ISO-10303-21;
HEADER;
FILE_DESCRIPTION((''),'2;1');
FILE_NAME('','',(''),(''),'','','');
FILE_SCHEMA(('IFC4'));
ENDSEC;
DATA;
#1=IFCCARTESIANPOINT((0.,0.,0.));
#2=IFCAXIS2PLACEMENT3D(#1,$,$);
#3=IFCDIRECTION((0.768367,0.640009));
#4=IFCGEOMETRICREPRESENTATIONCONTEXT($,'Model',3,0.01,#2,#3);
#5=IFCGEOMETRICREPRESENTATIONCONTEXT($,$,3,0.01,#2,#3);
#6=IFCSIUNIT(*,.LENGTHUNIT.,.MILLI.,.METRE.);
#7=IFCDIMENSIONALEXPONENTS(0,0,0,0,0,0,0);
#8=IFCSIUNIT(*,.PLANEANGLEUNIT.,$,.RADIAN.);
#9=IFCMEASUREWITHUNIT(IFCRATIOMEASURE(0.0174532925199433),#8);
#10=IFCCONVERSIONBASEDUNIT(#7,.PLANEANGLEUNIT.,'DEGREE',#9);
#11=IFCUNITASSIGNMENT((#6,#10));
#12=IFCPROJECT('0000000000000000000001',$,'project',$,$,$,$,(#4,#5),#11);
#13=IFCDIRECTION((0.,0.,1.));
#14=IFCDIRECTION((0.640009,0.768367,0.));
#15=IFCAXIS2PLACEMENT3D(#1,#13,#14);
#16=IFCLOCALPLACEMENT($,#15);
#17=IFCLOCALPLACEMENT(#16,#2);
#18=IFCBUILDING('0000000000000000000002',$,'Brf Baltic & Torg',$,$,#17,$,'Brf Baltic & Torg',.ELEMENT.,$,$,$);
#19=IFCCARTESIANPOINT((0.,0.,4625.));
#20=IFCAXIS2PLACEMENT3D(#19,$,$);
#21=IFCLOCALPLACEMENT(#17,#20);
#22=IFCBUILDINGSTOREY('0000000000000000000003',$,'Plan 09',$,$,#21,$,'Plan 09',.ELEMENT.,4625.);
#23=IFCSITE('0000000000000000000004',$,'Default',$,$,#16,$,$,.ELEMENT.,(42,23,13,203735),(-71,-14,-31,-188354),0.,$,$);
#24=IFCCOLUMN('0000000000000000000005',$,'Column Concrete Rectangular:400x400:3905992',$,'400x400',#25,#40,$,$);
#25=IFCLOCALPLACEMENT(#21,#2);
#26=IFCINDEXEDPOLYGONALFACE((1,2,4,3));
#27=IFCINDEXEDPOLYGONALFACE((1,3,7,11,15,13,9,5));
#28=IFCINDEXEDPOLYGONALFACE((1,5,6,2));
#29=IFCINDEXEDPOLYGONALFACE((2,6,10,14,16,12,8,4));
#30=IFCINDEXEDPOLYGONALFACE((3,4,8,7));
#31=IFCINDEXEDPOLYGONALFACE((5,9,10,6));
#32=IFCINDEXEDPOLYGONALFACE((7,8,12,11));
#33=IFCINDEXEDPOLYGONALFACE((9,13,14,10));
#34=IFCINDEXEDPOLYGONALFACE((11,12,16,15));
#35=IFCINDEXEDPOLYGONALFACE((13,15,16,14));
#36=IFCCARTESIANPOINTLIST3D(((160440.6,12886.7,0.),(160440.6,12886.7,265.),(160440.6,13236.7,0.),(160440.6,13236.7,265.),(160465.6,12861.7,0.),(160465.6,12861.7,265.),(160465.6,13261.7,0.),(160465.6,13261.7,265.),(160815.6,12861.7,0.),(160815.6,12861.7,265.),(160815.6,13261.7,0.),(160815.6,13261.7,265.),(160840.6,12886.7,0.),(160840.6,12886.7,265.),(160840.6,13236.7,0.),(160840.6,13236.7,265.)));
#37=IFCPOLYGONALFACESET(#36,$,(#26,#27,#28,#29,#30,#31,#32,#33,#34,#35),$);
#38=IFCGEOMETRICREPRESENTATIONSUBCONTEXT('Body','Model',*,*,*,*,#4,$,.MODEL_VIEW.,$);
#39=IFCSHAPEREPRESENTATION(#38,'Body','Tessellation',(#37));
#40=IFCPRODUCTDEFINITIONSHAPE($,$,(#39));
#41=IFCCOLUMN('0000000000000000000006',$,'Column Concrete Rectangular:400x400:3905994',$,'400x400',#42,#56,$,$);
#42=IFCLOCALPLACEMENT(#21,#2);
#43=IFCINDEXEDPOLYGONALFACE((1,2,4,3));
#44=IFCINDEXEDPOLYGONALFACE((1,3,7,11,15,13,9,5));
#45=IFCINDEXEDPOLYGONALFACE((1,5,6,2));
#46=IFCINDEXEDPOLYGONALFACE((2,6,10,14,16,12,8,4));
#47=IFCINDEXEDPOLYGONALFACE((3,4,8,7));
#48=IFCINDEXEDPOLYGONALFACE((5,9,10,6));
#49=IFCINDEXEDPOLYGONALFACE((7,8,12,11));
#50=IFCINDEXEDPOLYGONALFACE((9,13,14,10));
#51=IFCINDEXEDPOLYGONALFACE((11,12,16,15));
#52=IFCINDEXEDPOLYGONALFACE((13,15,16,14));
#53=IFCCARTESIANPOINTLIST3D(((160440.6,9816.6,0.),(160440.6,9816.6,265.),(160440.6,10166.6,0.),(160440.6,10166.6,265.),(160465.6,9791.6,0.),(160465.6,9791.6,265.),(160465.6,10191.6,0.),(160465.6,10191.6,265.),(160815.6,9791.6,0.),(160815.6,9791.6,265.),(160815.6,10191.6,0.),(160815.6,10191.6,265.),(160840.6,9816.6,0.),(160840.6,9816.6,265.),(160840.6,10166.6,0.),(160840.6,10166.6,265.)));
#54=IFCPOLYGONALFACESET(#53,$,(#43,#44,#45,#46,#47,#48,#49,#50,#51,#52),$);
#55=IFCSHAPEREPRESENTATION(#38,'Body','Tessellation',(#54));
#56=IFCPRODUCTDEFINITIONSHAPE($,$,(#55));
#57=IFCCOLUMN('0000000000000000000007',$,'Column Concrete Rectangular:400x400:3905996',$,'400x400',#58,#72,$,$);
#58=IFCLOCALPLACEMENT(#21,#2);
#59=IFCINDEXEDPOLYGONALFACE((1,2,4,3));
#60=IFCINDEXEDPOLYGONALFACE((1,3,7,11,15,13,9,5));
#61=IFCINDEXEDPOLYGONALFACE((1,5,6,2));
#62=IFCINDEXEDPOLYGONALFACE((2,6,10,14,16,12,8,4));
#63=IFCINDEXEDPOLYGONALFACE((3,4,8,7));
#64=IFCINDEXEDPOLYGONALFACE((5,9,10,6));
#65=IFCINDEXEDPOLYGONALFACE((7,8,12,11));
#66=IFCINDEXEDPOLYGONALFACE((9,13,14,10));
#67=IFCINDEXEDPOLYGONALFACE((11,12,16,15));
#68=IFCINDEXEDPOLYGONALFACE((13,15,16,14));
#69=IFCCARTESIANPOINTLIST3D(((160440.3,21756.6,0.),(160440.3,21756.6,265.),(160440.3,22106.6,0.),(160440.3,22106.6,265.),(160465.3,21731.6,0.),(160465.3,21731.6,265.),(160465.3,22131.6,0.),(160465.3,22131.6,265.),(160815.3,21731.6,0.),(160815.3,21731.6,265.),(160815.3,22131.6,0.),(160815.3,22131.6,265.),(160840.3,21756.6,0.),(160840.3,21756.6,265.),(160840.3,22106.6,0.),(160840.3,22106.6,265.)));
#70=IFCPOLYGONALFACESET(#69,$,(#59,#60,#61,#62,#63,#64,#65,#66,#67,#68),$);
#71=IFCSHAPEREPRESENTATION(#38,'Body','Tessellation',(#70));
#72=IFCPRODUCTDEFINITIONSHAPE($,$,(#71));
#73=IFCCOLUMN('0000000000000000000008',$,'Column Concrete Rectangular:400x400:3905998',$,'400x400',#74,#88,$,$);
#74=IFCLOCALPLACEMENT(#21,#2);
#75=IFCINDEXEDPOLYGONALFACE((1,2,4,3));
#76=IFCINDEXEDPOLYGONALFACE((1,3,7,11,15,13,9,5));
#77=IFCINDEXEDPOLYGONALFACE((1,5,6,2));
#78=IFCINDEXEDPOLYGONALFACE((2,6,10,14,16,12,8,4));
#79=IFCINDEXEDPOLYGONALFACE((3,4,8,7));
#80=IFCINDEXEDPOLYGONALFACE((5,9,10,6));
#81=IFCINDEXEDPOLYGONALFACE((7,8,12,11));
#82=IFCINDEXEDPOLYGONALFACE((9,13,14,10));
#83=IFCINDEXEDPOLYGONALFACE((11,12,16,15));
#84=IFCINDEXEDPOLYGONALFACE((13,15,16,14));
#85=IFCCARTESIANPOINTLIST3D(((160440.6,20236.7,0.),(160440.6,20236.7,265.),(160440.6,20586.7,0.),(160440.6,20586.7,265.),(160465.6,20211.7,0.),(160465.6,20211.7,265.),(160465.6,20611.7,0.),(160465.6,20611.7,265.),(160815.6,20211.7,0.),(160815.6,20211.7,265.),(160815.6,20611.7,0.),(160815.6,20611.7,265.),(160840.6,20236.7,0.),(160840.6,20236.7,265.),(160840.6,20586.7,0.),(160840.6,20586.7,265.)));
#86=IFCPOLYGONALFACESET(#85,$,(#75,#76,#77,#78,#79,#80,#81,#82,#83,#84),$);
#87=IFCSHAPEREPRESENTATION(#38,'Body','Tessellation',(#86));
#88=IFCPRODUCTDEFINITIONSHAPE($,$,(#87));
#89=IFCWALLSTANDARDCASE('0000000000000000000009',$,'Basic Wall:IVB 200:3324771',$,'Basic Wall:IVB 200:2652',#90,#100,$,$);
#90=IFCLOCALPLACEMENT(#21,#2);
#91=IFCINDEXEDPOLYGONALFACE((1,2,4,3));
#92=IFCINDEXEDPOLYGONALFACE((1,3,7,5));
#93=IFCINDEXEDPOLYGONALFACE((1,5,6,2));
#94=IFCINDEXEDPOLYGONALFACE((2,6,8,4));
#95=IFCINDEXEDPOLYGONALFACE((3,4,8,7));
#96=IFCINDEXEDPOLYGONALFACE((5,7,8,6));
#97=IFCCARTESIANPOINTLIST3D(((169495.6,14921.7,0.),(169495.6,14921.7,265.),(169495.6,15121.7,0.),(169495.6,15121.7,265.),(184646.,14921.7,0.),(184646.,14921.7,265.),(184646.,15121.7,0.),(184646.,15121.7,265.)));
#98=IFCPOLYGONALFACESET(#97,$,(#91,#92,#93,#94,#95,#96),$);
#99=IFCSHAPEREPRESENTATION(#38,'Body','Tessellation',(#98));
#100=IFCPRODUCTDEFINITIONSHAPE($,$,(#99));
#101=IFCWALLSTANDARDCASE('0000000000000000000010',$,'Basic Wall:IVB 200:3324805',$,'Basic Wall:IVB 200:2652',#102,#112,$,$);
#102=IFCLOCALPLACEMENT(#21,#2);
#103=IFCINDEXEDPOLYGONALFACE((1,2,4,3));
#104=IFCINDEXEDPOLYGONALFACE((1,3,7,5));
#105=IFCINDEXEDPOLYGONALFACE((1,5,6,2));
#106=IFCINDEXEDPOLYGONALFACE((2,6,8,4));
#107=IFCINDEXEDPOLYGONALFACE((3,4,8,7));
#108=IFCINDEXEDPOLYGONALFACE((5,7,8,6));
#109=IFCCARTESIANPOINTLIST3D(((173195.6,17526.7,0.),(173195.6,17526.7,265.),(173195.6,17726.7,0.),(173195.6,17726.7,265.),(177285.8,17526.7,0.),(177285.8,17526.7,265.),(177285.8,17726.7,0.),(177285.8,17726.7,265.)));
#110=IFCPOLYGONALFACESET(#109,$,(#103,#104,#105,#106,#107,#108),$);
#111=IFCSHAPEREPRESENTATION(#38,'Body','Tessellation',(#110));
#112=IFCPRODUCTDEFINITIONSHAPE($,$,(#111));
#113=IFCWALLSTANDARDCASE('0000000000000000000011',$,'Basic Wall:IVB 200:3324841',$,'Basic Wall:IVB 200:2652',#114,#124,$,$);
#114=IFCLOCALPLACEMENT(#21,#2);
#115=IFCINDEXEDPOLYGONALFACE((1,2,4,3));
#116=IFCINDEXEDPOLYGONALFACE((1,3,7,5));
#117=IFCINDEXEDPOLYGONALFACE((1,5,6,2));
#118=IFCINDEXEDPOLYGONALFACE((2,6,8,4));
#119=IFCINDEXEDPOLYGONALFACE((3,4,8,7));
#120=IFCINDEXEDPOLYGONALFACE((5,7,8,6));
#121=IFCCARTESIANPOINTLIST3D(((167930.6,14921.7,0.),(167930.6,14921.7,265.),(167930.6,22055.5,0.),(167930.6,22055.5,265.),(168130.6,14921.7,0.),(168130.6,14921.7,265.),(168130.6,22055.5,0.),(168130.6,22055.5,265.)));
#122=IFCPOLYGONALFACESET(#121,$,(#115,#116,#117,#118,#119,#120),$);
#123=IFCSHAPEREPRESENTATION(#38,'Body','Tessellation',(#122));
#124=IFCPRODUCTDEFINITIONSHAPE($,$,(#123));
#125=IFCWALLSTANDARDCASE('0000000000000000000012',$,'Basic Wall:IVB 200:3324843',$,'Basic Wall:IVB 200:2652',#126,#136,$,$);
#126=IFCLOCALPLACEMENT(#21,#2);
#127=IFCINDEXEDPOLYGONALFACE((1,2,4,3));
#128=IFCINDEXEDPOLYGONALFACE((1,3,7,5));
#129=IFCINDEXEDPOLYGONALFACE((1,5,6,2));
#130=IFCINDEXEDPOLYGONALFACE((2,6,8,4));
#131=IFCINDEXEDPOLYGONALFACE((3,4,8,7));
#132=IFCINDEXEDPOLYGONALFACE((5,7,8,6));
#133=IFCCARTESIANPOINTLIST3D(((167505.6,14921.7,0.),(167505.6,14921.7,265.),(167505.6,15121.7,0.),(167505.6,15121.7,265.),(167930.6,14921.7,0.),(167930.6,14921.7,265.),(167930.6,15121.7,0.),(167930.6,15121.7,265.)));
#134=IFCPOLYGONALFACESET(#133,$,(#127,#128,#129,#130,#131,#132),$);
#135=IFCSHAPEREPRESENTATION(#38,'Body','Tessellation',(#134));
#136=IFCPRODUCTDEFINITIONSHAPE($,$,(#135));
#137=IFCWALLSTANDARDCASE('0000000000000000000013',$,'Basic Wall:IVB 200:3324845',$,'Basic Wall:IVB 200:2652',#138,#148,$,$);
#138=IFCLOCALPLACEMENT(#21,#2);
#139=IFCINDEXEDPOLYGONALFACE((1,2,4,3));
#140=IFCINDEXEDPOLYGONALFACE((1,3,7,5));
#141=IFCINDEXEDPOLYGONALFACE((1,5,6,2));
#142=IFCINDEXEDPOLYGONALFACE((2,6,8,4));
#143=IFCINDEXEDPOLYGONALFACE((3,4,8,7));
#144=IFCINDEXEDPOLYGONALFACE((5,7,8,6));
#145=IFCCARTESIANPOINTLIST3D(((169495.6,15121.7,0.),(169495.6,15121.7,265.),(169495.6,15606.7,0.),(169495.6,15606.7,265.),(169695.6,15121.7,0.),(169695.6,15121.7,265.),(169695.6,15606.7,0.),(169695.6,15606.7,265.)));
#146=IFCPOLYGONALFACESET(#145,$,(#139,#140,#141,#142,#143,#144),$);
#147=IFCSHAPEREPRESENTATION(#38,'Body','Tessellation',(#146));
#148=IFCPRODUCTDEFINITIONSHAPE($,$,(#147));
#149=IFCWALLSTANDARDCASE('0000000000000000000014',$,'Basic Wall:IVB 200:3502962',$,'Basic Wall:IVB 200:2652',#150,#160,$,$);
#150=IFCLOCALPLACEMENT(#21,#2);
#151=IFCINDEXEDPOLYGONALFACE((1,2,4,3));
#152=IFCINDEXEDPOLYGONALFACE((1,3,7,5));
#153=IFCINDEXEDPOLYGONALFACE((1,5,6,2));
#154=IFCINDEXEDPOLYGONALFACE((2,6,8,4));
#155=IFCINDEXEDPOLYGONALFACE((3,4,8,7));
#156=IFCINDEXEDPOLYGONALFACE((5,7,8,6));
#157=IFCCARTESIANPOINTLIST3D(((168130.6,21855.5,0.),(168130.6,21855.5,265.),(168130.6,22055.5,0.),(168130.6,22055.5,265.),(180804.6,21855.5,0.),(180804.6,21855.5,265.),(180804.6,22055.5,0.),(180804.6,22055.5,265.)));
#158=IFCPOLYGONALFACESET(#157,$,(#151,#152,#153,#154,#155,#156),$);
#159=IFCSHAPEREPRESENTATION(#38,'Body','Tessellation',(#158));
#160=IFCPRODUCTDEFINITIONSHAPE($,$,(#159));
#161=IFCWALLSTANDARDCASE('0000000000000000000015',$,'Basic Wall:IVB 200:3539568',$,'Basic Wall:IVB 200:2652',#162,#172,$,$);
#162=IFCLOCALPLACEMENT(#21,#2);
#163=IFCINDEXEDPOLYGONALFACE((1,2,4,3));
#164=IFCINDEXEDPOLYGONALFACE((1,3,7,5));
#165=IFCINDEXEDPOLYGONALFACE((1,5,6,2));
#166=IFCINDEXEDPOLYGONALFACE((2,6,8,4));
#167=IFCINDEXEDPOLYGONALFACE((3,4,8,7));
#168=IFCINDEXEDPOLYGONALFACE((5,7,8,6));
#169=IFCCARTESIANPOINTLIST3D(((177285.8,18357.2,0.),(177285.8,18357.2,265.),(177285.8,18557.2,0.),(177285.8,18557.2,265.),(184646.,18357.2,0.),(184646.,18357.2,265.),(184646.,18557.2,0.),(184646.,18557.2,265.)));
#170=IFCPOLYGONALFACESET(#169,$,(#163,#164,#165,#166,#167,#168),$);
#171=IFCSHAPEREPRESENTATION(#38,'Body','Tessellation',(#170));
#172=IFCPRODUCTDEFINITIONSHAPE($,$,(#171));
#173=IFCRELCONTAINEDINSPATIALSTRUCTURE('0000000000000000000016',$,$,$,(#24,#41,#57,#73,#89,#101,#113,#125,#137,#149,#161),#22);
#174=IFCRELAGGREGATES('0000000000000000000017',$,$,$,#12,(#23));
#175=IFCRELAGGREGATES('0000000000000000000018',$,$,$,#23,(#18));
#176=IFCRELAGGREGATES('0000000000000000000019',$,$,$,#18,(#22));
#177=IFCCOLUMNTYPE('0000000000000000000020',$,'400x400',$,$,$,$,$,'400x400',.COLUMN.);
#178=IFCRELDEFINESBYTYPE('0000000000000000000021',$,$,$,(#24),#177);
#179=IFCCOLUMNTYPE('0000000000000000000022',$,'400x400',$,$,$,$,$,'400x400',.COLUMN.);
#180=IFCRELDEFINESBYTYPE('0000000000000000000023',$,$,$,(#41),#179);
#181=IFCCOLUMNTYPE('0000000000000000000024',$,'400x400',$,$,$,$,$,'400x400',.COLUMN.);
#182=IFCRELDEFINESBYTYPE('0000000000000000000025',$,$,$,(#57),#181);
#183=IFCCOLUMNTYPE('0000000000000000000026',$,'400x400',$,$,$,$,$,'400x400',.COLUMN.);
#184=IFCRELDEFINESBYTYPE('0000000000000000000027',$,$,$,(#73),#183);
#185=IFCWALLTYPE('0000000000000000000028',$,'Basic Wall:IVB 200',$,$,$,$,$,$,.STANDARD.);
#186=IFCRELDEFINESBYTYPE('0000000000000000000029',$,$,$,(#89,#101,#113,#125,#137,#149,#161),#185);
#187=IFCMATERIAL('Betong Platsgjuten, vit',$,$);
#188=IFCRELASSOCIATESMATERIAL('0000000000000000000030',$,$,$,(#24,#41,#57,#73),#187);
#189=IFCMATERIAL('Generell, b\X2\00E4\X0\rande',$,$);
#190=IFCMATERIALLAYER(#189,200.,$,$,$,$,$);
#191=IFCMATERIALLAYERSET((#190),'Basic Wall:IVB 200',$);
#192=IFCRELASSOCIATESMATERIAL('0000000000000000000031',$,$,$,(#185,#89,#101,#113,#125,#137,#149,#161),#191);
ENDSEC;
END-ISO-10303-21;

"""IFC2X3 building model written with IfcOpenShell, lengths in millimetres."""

from ifc_helpers import new_model, entity, si_unit, converted_unit, direction, frame, frame_2d, origin, place, context, subcontext, project, spatial, polyline, rectangle, outline, extrude, clip, halfspace, source, transform, mapped, material, layer, layer_set, layer_usage, type_object, type_shapes, element, save


model = new_model("IFC2X3")

# Units and contexts
model_context = context("Model", 3, precision=0.01, world=origin(), true_north=direction((0.768367, 0.640009)))
context_of_model = context(None, 3, precision=0.01, world=origin(), true_north=direction((0.768367, 0.640009)))
body_context = subcontext(model_context, "Body", "Model", "MODEL_VIEW")
ifc_project = project(units=[si_unit("LENGTHUNIT", "METRE", prefix="MILLI"), converted_unit("PLANEANGLEUNIT", "DEGREE", entity("IfcRatioMeasure", 0.0174532925199433), si_unit("PLANEANGLEUNIT", "RADIAN"), dimensions=[0, 0, 0, 0, 0, 0, 0])], contexts=[model_context, context_of_model])

# Site, building, storey
site_placement = place(None, frame((0.0, 0.0, 0.0), z_axis=(0.0, 0.0, 1.0), x_axis=(0.640009, 0.768367, 0.0)))
site = spatial("IfcSite", under=ifc_project, at=site_placement, Name="Default", CompositionType="ELEMENT", RefLatitude=(42, 23, 13, 203735), RefLongitude=(-71, -14, -31, -188354), RefElevation=0.0)
building_placement = place(site_placement, origin())
building = spatial("IfcBuilding", under=site, at=building_placement, Name="Brf Baltic & Torg", LongName="Brf Baltic & Torg", CompositionType="ELEMENT")
storey_placement = place(building_placement, frame((0.0, 0.0, 4625.0)))
storey = spatial("IfcBuildingStorey", under=building, at=storey_placement, Name="Plan 09", LongName="Plan 09", CompositionType="ELEMENT", Elevation=4625.0)

# Columns
ifc_material_1 = material(Name="Betong Platsgjuten, vit")
column_type_1 = type_object("IfcColumnType", Name="400x400", ElementType="400x400", PredefinedType="COLUMN")
shared_shape_1 = source(origin(), body_context, "Body", "SweptSolid", [
    extrude(outline(polyline([(-175.0, -200.0), (175.0, -200.0), (200.0, -175.0), (200.0, 175.0), (175.0, 200.0), (-175.0, 200.0), (-200.0, 175.0), (-200.0, -175.0), (-175.0, -200.0)])), frame((0.0, 0.0, 4625.0), z_axis=(0.0, 0.0, 1.0), x_axis=(0.0, -1.0, 0.0)), (0.0, 0.0, 1.0), 265.0),
])
type_shapes(column_type_1, [shared_shape_1])
column_1_placement = place(storey_placement, frame((160640.6, 13061.7, -4625.0)))
element("IfcColumn", 1, at=column_1_placement, inside=storey, type_object=column_type_1, material=ifc_material_1, Name="Column Concrete Rectangular:400x400:3905992", ObjectType="400x400", context=body_context, shape_type="MappedRepresentation", body=[
    mapped(shared_shape_1, transform((0.0, 0.0, 0.0), scale=1.0)),
])
column_type_2 = type_object("IfcColumnType", Name="400x400", ElementType="400x400", PredefinedType="COLUMN")
shared_shape_2 = source(origin(), body_context, "Body", "SweptSolid", [
    extrude(outline(polyline([(-175.0, -200.0), (175.0, -200.0), (200.0, -175.0), (200.0, 175.0), (175.0, 200.0), (-175.0, 200.0), (-200.0, 175.0), (-200.0, -175.0), (-175.0, -200.0)])), frame((0.0, 0.0, 4625.0), z_axis=(0.0, 0.0, 1.0), x_axis=(0.0, -1.0, 0.0)), (0.0, 0.0, 1.0), 265.0),
])
type_shapes(column_type_2, [shared_shape_2])
column_2_placement = place(storey_placement, frame((160640.6, 9991.6, -4625.0)))
element("IfcColumn", 2, at=column_2_placement, inside=storey, type_object=column_type_2, material=ifc_material_1, Name="Column Concrete Rectangular:400x400:3905994", ObjectType="400x400", context=body_context, shape_type="MappedRepresentation", body=[
    mapped(shared_shape_2, transform((0.0, 0.0, 0.0), scale=1.0)),
])
column_type_3 = type_object("IfcColumnType", Name="400x400", ElementType="400x400", PredefinedType="COLUMN")
shared_shape_3 = source(origin(), body_context, "Body", "SweptSolid", [
    extrude(outline(polyline([(-175.0, -200.0), (175.0, -200.0), (200.0, -175.0), (200.0, 175.0), (175.0, 200.0), (-175.0, 200.0), (-200.0, 175.0), (-200.0, -175.0), (-175.0, -200.0)])), frame((0.0, 0.0, 4625.0), z_axis=(0.0, 0.0, 1.0), x_axis=(0.0, -1.0, 0.0)), (0.0, 0.0, 1.0), 265.0),
])
type_shapes(column_type_3, [shared_shape_3])
column_3_placement = place(storey_placement, frame((160640.3, 21931.6, -4625.0)))
element("IfcColumn", 3, at=column_3_placement, inside=storey, type_object=column_type_3, material=ifc_material_1, Name="Column Concrete Rectangular:400x400:3905996", ObjectType="400x400", context=body_context, shape_type="MappedRepresentation", body=[
    mapped(shared_shape_3, transform((0.0, 0.0, 0.0), scale=1.0)),
])
column_type_4 = type_object("IfcColumnType", Name="400x400", ElementType="400x400", PredefinedType="COLUMN")
shared_shape_4 = source(origin(), body_context, "Body", "SweptSolid", [
    extrude(outline(polyline([(-175.0, -200.0), (175.0, -200.0), (200.0, -175.0), (200.0, 175.0), (175.0, 200.0), (-175.0, 200.0), (-200.0, 175.0), (-200.0, -175.0), (-175.0, -200.0)])), frame((0.0, 0.0, 4625.0), z_axis=(0.0, 0.0, 1.0), x_axis=(0.0, -1.0, 0.0)), (0.0, 0.0, 1.0), 265.0),
])
type_shapes(column_type_4, [shared_shape_4])
column_4_placement = place(storey_placement, frame((160640.6, 20411.7, -4625.0)))
element("IfcColumn", 4, at=column_4_placement, inside=storey, type_object=column_type_4, material=ifc_material_1, Name="Column Concrete Rectangular:400x400:3905998", ObjectType="400x400", context=body_context, shape_type="MappedRepresentation", body=[
    mapped(shared_shape_4, transform((0.0, 0.0, 0.0), scale=1.0)),
])

# Wall
ifc_material_2 = material(Name="Generell, bärande")
ifc_layer = layer(ifc_material_2, 200.0)
ifc_layer_set = layer_set([ifc_layer], Name="Basic Wall:IVB 200")
ifc_layer_usage_1 = layer_usage(ifc_layer_set, "AXIS2", "NEGATIVE", 100.0)
wall_type = type_object("IfcWallType", Name="Basic Wall:IVB 200", PredefinedType="STANDARD", material=ifc_layer_set)
wall_1_placement = place(storey_placement, frame((169495.6, 15021.7, 0.0)))
element("IfcWallStandardCase", 5, at=wall_1_placement, inside=storey, type_object=wall_type, material=ifc_layer_usage_1, Name="Basic Wall:IVB 200:3324771", ObjectType="Basic Wall:IVB 200:2652", context=body_context, shape_type="Clipping", body=[
    clip(extrude(rectangle(XDim=15150.4, YDim=200.0, at=frame_2d((7575.2, 0.0), x_axis=(-1.0, 0.0))), origin(), (0.0, 0.0, 1.0), 265.0), halfspace(origin(), True)),
])

# Walls
ifc_layer_usage_2 = layer_usage(ifc_layer_set, "AXIS2", "NEGATIVE", 100.0)
wall_2_placement = place(storey_placement, frame((173195.6, 17626.7, 0.0)))
element("IfcWallStandardCase", 6, at=wall_2_placement, inside=storey, type_object=wall_type, material=ifc_layer_usage_2, Name="Basic Wall:IVB 200:3324805", ObjectType="Basic Wall:IVB 200:2652", context=body_context, shape_type="Clipping", body=[
    clip(extrude(rectangle(XDim=4090.2, YDim=200.0, at=frame_2d((2045.1, 0.0), x_axis=(-1.0, 0.0))), origin(), (0.0, 0.0, 1.0), 265.0), halfspace(origin(), True)),
])
ifc_layer_usage_3 = layer_usage(ifc_layer_set, "AXIS2", "NEGATIVE", 100.0)
wall_3_placement = place(storey_placement, frame((168030.6, 22055.5, 0.0), z_axis=(0.0, 0.0, 1.0), x_axis=(0.0, -1.0, 0.0)))
element("IfcWallStandardCase", 7, at=wall_3_placement, inside=storey, type_object=wall_type, material=ifc_layer_usage_3, Name="Basic Wall:IVB 200:3324841", ObjectType="Basic Wall:IVB 200:2652", context=body_context, shape_type="Clipping", body=[
    clip(extrude(rectangle(XDim=7133.7, YDim=200.0, at=frame_2d((3566.9, 0.0), x_axis=(-1.0, 0.0))), origin(), (0.0, 0.0, 1.0), 265.0), halfspace(origin(), True)),
])

# Walls
ifc_layer_usage_4 = layer_usage(ifc_layer_set, "AXIS2", "POSITIVE", -100.0)
wall_4_placement = place(storey_placement, frame((167930.6, 15021.7, 0.0), z_axis=(0.0, 0.0, 1.0), x_axis=(-1.0, 0.0, 0.0)))
element("IfcWallStandardCase", 8, at=wall_4_placement, inside=storey, type_object=wall_type, material=ifc_layer_usage_4, Name="Basic Wall:IVB 200:3324843", ObjectType="Basic Wall:IVB 200:2652", context=body_context, shape_type="Clipping", body=[
    clip(extrude(rectangle(XDim=425.0, YDim=200.0, at=frame_2d((212.5, 0.0), x_axis=(-1.0, 0.0))), origin(), (0.0, 0.0, 1.0), 265.0), halfspace(origin(), True)),
])
ifc_layer_usage_5 = layer_usage(ifc_layer_set, "AXIS2", "POSITIVE", -100.0)
wall_5_placement = place(storey_placement, frame((169595.6, 15606.7, 0.0), z_axis=(0.0, 0.0, 1.0), x_axis=(0.0, -1.0, 0.0)))
element("IfcWallStandardCase", 9, at=wall_5_placement, inside=storey, type_object=wall_type, material=ifc_layer_usage_5, Name="Basic Wall:IVB 200:3324845", ObjectType="Basic Wall:IVB 200:2652", context=body_context, shape_type="Clipping", body=[
    clip(extrude(rectangle(XDim=485.0, YDim=200.0, at=frame_2d((242.5, 0.0), x_axis=(-1.0, 0.0))), origin(), (0.0, 0.0, 1.0), 265.0), halfspace(origin(), True)),
])
ifc_layer_usage_6 = layer_usage(ifc_layer_set, "AXIS2", "NEGATIVE", 100.0)
wall_6_placement = place(storey_placement, frame((168130.6, 21955.5, 0.0)))
element("IfcWallStandardCase", 10, at=wall_6_placement, inside=storey, type_object=wall_type, material=ifc_layer_usage_6, Name="Basic Wall:IVB 200:3502962", ObjectType="Basic Wall:IVB 200:2652", context=body_context, shape_type="Clipping", body=[
    clip(extrude(rectangle(XDim=12674.0, YDim=200.0, at=frame_2d((6337.0, 0.0), x_axis=(-1.0, 0.0))), origin(), (0.0, 0.0, 1.0), 265.0), halfspace(origin(), True)),
])
ifc_layer_usage_7 = layer_usage(ifc_layer_set, "AXIS2", "NEGATIVE", 100.0)
wall_7_placement = place(storey_placement, frame((177285.8, 18457.2, 0.0)))
element("IfcWallStandardCase", 11, at=wall_7_placement, inside=storey, type_object=wall_type, material=ifc_layer_usage_7, Name="Basic Wall:IVB 200:3539568", ObjectType="Basic Wall:IVB 200:2652", context=body_context, shape_type="Clipping", body=[
    clip(extrude(rectangle(XDim=7360.2, YDim=200.0, at=frame_2d((3680.1, 0.0), x_axis=(-1.0, 0.0))), origin(), (0.0, 0.0, 1.0), 265.0), halfspace(origin(), True)),
])

save(model, "model.ifc")
